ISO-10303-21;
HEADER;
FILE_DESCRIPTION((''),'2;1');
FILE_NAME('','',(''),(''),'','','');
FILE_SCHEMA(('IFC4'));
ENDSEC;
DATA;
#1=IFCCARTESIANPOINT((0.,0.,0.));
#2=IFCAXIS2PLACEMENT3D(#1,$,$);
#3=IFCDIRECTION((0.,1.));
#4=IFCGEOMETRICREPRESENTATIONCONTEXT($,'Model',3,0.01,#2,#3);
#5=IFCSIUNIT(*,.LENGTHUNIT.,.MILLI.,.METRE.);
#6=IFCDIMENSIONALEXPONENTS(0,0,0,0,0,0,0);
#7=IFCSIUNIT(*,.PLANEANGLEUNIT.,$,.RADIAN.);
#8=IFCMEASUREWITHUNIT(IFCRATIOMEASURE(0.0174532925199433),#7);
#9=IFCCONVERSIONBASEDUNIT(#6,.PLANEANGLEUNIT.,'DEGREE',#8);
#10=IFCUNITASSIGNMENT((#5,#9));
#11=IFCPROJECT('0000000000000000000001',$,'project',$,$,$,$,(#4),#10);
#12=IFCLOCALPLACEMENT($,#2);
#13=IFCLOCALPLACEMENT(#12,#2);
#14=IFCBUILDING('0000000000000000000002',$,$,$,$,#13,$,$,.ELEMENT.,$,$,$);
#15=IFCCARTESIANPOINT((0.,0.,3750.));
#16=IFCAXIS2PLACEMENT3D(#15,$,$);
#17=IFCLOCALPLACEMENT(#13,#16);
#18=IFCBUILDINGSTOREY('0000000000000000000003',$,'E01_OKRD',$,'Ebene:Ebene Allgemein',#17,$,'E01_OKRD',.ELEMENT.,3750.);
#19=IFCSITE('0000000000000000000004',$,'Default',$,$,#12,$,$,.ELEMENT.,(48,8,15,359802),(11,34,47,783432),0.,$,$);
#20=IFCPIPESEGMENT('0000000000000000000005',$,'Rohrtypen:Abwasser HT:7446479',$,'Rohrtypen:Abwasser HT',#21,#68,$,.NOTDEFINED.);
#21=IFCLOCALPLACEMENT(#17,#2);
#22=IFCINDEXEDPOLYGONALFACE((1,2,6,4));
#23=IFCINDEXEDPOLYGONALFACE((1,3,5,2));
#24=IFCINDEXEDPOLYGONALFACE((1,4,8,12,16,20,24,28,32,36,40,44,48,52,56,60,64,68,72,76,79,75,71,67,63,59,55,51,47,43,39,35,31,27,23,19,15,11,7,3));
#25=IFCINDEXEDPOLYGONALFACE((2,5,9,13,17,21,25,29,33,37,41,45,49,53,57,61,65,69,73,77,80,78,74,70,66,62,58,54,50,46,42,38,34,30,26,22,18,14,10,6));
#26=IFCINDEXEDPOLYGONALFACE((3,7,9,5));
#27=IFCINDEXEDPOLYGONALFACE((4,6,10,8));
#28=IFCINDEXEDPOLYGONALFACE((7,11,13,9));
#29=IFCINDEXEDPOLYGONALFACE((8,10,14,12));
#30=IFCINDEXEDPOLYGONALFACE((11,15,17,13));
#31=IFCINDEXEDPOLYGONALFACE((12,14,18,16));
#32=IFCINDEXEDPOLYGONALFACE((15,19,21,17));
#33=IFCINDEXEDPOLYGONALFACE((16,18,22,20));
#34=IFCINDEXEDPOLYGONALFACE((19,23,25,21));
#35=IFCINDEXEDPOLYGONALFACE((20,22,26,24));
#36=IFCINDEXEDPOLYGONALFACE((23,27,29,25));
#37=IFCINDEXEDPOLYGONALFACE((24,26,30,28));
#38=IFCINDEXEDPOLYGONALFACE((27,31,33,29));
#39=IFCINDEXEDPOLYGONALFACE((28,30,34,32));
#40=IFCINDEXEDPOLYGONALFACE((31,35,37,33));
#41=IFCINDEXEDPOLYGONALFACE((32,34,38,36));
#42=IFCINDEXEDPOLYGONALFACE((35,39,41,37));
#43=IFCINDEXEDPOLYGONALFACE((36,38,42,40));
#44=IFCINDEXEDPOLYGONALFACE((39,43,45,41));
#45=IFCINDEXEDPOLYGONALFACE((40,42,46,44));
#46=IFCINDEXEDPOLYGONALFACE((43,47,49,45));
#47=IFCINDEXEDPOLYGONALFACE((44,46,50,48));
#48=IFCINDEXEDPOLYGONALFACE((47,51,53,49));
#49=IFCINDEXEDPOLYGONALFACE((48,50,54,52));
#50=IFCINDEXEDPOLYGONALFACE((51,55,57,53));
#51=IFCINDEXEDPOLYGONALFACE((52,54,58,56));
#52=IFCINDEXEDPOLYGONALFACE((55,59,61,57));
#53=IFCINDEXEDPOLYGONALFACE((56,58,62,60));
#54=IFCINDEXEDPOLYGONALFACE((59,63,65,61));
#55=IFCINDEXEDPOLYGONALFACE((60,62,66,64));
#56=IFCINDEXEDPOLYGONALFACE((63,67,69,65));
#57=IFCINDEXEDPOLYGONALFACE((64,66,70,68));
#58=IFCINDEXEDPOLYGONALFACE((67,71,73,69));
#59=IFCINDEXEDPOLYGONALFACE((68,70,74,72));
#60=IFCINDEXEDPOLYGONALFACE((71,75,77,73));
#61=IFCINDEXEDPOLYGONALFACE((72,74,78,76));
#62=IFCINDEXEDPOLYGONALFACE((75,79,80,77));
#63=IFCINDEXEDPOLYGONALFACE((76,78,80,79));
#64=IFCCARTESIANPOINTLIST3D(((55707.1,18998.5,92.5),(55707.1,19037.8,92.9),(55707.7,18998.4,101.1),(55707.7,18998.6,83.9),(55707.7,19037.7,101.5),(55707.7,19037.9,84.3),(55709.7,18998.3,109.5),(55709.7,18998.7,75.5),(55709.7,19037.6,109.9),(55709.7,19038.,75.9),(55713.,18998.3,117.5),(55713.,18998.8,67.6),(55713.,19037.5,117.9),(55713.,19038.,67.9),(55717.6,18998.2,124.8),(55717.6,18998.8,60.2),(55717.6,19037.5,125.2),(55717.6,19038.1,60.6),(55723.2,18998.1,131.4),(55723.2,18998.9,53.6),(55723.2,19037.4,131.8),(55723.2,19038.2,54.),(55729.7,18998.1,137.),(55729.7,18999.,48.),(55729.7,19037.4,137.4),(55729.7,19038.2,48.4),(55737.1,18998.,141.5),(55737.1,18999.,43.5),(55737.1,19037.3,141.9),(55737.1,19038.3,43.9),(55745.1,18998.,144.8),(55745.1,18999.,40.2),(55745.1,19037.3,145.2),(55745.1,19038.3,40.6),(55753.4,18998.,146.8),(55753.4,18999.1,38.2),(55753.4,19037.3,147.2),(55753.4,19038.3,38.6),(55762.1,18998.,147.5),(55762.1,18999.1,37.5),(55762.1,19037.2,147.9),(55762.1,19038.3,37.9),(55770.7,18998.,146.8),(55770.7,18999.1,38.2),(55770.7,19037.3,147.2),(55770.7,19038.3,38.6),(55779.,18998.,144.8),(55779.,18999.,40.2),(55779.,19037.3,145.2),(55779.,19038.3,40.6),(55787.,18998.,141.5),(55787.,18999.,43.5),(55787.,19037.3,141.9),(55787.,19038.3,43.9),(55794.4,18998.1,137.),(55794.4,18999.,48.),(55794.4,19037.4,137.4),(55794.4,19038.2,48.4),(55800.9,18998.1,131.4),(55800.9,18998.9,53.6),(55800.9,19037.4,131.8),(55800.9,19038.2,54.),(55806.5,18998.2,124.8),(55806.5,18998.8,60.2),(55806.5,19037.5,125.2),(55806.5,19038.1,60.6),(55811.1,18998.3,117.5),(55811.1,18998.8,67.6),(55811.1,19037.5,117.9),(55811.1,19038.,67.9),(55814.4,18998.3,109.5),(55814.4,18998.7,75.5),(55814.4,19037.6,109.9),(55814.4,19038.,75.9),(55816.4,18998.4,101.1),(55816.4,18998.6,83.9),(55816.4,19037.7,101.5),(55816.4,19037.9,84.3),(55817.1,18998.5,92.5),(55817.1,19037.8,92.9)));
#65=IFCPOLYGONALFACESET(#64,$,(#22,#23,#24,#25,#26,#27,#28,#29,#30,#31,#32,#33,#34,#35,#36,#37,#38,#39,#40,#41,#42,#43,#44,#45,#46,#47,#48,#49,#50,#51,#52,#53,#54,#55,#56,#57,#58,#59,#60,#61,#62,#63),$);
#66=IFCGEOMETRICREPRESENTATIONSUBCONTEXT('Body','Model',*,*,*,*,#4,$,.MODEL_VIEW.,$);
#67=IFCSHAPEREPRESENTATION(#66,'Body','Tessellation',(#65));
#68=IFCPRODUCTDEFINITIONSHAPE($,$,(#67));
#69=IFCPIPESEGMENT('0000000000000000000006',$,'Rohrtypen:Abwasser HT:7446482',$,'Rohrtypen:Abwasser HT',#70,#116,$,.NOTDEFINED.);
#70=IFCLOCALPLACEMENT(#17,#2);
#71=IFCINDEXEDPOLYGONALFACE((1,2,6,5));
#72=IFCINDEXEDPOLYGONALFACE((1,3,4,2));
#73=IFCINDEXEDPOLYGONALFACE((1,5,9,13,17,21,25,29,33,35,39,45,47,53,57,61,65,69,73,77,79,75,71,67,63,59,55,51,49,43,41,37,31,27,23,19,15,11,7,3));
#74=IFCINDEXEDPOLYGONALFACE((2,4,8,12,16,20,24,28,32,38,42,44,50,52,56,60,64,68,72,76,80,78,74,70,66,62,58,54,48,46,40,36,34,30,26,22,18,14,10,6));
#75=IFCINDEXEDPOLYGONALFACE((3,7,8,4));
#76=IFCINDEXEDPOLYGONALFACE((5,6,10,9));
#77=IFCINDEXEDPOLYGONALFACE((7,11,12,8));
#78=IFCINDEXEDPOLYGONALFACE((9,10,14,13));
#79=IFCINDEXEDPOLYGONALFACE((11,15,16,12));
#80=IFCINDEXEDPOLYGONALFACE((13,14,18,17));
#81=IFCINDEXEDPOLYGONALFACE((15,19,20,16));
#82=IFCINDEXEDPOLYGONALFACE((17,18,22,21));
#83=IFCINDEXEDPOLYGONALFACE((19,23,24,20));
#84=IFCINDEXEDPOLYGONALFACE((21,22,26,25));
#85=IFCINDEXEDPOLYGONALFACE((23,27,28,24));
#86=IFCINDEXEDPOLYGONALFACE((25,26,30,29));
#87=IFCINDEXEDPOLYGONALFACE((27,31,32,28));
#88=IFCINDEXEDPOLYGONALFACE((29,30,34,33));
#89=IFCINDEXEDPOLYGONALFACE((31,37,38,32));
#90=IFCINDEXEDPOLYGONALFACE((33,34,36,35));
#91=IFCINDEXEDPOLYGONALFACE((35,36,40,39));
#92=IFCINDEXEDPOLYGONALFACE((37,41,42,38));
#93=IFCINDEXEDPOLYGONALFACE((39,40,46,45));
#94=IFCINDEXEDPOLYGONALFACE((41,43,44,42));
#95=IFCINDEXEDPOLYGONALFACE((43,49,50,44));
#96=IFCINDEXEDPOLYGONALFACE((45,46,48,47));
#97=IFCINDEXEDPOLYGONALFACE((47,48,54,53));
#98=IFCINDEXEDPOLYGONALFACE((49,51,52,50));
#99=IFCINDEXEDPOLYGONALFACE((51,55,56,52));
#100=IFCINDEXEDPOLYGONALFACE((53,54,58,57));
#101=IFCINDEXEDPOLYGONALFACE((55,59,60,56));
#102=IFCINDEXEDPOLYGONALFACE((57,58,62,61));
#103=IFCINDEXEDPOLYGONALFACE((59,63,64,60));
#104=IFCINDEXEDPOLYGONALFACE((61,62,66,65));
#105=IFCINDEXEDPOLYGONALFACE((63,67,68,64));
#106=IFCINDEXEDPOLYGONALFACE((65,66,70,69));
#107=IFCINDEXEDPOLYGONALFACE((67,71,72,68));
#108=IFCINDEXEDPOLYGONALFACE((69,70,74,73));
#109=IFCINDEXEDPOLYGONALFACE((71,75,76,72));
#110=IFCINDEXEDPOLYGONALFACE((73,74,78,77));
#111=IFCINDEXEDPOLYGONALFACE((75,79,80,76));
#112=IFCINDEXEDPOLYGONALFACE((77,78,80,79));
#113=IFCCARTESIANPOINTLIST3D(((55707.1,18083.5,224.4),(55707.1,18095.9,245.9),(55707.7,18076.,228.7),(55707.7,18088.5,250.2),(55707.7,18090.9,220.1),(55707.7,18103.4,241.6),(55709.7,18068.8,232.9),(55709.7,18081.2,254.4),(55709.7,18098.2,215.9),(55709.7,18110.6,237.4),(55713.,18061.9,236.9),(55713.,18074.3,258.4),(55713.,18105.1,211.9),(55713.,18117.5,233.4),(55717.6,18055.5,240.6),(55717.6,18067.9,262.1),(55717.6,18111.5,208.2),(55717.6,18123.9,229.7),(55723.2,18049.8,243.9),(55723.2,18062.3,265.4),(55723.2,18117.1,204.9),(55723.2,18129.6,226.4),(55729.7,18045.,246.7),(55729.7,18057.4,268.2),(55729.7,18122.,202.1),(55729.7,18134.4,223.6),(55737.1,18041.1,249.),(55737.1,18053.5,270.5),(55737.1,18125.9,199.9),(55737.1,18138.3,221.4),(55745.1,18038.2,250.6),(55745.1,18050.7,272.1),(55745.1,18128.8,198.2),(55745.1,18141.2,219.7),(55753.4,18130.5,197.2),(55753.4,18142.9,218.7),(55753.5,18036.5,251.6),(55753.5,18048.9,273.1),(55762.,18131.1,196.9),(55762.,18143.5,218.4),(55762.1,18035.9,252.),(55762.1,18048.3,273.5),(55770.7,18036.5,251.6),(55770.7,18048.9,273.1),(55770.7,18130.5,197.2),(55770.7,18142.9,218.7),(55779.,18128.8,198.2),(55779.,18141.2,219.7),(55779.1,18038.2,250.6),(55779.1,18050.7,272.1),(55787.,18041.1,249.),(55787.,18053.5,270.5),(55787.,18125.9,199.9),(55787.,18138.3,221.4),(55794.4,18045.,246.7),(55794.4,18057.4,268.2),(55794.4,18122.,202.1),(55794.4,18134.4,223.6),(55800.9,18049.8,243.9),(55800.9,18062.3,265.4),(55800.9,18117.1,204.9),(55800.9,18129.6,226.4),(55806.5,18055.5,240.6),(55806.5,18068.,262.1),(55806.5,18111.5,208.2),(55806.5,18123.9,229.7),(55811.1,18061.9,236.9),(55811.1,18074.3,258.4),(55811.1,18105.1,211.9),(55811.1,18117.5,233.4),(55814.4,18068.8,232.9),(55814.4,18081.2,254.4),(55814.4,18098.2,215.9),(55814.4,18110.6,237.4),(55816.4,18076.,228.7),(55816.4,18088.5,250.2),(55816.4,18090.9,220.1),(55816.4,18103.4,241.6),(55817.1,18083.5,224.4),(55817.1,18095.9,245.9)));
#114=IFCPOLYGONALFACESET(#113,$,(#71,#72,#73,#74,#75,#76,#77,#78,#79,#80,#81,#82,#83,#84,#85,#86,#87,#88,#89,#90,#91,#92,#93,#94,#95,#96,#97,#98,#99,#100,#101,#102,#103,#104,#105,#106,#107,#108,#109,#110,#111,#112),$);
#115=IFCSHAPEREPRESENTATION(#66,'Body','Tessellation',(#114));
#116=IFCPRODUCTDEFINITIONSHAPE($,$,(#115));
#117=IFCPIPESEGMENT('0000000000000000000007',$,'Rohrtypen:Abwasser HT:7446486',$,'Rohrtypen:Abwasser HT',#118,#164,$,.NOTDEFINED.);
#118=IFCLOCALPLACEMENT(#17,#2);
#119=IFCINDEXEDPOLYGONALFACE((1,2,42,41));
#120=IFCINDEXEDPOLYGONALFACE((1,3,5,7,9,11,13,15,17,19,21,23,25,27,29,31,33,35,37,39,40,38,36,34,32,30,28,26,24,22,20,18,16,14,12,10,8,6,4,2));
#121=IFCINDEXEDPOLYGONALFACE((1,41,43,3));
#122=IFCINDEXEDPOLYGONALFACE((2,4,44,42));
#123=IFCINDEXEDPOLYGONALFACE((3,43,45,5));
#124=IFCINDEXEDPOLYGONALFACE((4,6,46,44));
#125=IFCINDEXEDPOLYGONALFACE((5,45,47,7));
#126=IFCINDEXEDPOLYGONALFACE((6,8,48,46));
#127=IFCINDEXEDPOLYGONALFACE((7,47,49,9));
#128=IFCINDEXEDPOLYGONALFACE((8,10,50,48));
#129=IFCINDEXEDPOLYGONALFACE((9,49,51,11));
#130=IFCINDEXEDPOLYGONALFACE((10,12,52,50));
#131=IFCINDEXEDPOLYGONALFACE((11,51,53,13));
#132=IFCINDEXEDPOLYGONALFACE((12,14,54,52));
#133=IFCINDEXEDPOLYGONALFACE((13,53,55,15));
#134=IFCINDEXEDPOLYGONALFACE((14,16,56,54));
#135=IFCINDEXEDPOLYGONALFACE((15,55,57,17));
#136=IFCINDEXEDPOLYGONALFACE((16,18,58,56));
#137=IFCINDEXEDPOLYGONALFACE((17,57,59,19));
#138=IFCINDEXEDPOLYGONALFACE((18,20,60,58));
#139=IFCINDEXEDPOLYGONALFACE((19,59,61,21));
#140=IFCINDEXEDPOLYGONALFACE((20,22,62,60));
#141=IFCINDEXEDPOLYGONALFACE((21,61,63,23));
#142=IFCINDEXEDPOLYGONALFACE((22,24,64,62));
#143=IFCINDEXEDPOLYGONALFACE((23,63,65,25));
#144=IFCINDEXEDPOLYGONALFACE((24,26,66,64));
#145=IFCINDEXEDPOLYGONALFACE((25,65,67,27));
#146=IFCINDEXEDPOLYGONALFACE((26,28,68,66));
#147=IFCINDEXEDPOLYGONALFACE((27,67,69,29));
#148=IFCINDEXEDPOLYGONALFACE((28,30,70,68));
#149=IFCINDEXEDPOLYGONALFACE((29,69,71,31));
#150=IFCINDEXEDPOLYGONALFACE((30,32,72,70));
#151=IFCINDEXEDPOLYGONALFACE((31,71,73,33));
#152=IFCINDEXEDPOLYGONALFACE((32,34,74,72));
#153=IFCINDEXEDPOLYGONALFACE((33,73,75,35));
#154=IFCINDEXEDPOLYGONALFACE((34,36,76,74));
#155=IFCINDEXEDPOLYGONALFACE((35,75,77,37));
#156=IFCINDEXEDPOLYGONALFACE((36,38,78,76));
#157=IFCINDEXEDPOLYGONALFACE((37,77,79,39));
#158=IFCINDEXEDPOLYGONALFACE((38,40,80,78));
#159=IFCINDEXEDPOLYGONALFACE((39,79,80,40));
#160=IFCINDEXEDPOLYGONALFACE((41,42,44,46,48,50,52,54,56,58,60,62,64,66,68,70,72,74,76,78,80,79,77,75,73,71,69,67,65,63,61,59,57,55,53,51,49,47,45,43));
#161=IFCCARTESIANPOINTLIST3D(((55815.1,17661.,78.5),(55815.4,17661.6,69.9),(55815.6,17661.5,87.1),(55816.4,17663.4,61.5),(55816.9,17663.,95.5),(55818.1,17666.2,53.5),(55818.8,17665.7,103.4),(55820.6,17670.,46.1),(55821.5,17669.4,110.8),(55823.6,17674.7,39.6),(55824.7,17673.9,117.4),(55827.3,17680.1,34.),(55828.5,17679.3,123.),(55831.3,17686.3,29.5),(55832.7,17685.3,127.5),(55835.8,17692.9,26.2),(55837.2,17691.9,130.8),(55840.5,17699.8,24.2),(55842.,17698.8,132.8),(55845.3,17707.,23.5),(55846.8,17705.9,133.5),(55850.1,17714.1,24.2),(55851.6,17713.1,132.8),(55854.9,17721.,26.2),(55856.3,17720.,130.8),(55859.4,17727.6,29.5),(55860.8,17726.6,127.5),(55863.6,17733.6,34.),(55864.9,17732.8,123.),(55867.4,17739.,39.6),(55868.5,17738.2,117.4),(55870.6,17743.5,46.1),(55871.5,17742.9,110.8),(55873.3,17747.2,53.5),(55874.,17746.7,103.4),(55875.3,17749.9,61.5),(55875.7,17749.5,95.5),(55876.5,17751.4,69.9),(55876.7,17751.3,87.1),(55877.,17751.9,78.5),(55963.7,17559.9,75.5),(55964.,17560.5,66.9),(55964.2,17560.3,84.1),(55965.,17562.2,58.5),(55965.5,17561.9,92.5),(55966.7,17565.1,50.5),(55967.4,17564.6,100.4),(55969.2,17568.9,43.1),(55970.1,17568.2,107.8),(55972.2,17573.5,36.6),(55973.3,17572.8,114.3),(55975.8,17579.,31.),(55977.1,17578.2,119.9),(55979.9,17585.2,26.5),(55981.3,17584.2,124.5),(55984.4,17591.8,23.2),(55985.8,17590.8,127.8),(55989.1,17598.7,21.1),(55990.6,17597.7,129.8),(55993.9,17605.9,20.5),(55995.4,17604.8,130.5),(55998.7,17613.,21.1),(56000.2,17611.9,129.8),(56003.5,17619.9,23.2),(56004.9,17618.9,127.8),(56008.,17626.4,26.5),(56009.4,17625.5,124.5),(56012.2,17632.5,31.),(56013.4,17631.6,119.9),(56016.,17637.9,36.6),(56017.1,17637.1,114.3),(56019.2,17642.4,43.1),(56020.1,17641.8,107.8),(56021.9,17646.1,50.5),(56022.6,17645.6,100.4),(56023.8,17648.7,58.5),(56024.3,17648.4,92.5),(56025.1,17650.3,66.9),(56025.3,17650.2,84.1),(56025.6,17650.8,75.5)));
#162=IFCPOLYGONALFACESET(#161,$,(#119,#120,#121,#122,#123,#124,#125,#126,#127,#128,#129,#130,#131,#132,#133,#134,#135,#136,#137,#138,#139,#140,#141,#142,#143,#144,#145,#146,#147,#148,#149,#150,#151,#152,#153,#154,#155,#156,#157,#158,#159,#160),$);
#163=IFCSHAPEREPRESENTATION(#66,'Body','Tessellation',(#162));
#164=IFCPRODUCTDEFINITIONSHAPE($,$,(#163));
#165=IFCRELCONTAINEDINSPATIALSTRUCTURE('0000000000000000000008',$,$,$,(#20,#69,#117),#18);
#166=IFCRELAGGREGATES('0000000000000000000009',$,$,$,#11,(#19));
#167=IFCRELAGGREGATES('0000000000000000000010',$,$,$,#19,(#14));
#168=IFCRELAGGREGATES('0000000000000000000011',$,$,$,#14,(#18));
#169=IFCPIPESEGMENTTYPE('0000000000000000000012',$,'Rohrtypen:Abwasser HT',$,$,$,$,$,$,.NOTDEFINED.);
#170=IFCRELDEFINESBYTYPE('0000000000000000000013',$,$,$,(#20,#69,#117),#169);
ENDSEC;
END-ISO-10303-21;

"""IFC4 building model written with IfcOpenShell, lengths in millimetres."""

from ifc_helpers import new_model, entity, si_unit, converted_unit, direction, frame, origin, place, context, subcontext, project, spatial, indexed_curve, outline, extrude, type_object, element, save


model = new_model("IFC4")

# Units and contexts
model_context = context("Model", 3, precision=0.01, world=origin(), true_north=direction((0.0, 1.0)))
body_context = subcontext(model_context, "Body", "Model", "MODEL_VIEW")
ifc_project = project(units=[si_unit("LENGTHUNIT", "METRE", prefix="MILLI"), converted_unit("PLANEANGLEUNIT", "DEGREE", entity("IfcRatioMeasure", 0.0174532925199433), si_unit("PLANEANGLEUNIT", "RADIAN"), dimensions=[0, 0, 0, 0, 0, 0, 0])], contexts=[model_context])

# Site, building, storey
site_placement = place(None, origin())
site = spatial("IfcSite", under=ifc_project, at=site_placement, Name="Default", CompositionType="ELEMENT", RefLatitude=(48, 8, 15, 359802), RefLongitude=(11, 34, 47, 783432), RefElevation=0.0)
building_placement = place(site_placement, origin())
building = spatial("IfcBuilding", under=site, at=building_placement, CompositionType="ELEMENT")
storey_placement = place(building_placement, frame((0.0, 0.0, 3750.0)))
storey = spatial("IfcBuildingStorey", under=building, at=storey_placement, Name="E01_OKRD", ObjectType="Ebene:Ebene Allgemein", LongName="E01_OKRD", CompositionType="ELEMENT", Elevation=3750.0)

# Pipe segments
pipe_segment_type_1 = type_object("IfcPipeSegmentType", Name="Rohrtypen:Abwasser HT", PredefinedType="NOTDEFINED")
pipe_segment_1_placement = place(storey_placement, origin())
element("IfcPipeSegment", 1, at=pipe_segment_1_placement, inside=storey, type_object=pipe_segment_type_1, Name="Rohrtypen:Abwasser HT:7446479", ObjectType="Rohrtypen:Abwasser HT", PredefinedType="NOTDEFINED", context=body_context, shape_type="SweptSolid", body=[
    extrude(outline(indexed_curve([(55.0, 0.0), (54.3, 8.6), (52.3, 17.0), (49.0, 25.0), (44.5, 32.3), (38.9, 38.9), (32.3, 44.5), (25.0, 49.0), (17.0, 52.3), (8.6, 54.3), (0.0, 55.0), (-8.6, 54.3), (-17.0, 52.3), (-25.0, 49.0), (-32.3, 44.5), (-38.9, 38.9), (-44.5, 32.3), (-49.0, 25.0), (-52.3, 17.0), (-54.3, 8.6), (-55.0, 0.0), (-54.3, -8.6), (-52.3, -17.0), (-49.0, -25.0), (-44.5, -32.3), (-38.9, -38.9), (-32.3, -44.5), (-25.0, -49.0), (-17.0, -52.3), (-8.6, -54.3), (0.0, -55.0), (8.6, -54.3), (17.0, -52.3), (25.0, -49.0), (32.3, -44.5), (38.9, -38.9), (44.5, -32.3), (49.0, -25.0), (52.3, -17.0), (54.3, -8.6), (55.0, 0.0)], self_intersect=False)), frame((55762.1, 18998.5, 92.5), z_axis=(0.0, 0.99995, 0.01), x_axis=(1.0, 0.0, 0.0)), (0.0, 0.0, 1.0), 39.3),
])
pipe_segment_2_placement = place(storey_placement, origin())
element("IfcPipeSegment", 2, at=pipe_segment_2_placement, inside=storey, type_object=pipe_segment_type_1, Name="Rohrtypen:Abwasser HT:7446482", ObjectType="Rohrtypen:Abwasser HT", PredefinedType="NOTDEFINED", context=body_context, shape_type="SweptSolid", body=[
    extrude(outline(indexed_curve([(55.0, 0.0), (54.3, 8.6), (52.3, 17.0), (49.0, 25.0), (44.5, 32.3), (38.9, 38.9), (32.3, 44.5), (25.0, 49.0), (17.0, 52.3), (8.6, 54.3), (0.0, 55.0), (-8.6, 54.3), (-17.0, 52.3), (-25.0, 49.0), (-32.3, 44.5), (-38.9, 38.9), (-44.5, 32.3), (-49.0, 25.0), (-52.3, 17.0), (-54.3, 8.6), (-55.0, 0.0), (-54.3, -8.6), (-52.3, -17.0), (-49.0, -25.0), (-44.5, -32.3), (-38.9, -38.9), (-32.3, -44.5), (-25.0, -49.0), (-17.0, -52.3), (-8.6, -54.3), (0.0, -55.0), (8.6, -54.3), (17.0, -52.3), (25.0, -49.0), (32.3, -44.5), (38.9, -38.9), (44.5, -32.3), (49.0, -25.0), (52.3, -17.0), (54.3, -8.6), (55.0, 0.0)], self_intersect=False)), frame((55762.1, 18083.5, 224.4), z_axis=(-0.000029, 0.500961, 0.86547), x_axis=(-1.0, -0.000059, 0.0)), (0.0, 0.0, 1.0), 24.8),
])
pipe_segment_3_placement = place(storey_placement, origin())
element("IfcPipeSegment", 3, at=pipe_segment_3_placement, inside=storey, type_object=pipe_segment_type_1, Name="Rohrtypen:Abwasser HT:7446486", ObjectType="Rohrtypen:Abwasser HT", PredefinedType="NOTDEFINED", context=body_context, shape_type="SweptSolid", body=[
    extrude(outline(indexed_curve([(55.0, 0.0), (54.3, 8.6), (52.3, 17.0), (49.0, 25.0), (44.5, 32.3), (38.9, 38.9), (32.3, 44.5), (25.0, 49.0), (17.0, 52.3), (8.6, 54.3), (0.0, 55.0), (-8.6, 54.3), (-17.0, 52.3), (-25.0, 49.0), (-32.3, 44.5), (-38.9, 38.9), (-44.5, 32.3), (-49.0, 25.0), (-52.3, 17.0), (-54.3, 8.6), (-55.0, 0.0), (-54.3, -8.6), (-52.3, -17.0), (-49.0, -25.0), (-44.5, -32.3), (-38.9, -38.9), (-32.3, -44.5), (-25.0, -49.0), (-17.0, -52.3), (-8.6, -54.3), (0.0, -55.0), (8.6, -54.3), (17.0, -52.3), (25.0, -49.0), (32.3, -44.5), (38.9, -38.9), (44.5, -32.3), (49.0, -25.0), (52.3, -17.0), (54.3, -8.6), (55.0, 0.0)], self_intersect=False)), frame((55846.1, 17706.5, 78.5), z_axis=(0.826611, -0.562525, -0.016755), x_axis=(-0.562604, -0.826727, 0.0)), (0.0, 0.0, 1.0), 179.8),
])

save(model, "model.ifc")
